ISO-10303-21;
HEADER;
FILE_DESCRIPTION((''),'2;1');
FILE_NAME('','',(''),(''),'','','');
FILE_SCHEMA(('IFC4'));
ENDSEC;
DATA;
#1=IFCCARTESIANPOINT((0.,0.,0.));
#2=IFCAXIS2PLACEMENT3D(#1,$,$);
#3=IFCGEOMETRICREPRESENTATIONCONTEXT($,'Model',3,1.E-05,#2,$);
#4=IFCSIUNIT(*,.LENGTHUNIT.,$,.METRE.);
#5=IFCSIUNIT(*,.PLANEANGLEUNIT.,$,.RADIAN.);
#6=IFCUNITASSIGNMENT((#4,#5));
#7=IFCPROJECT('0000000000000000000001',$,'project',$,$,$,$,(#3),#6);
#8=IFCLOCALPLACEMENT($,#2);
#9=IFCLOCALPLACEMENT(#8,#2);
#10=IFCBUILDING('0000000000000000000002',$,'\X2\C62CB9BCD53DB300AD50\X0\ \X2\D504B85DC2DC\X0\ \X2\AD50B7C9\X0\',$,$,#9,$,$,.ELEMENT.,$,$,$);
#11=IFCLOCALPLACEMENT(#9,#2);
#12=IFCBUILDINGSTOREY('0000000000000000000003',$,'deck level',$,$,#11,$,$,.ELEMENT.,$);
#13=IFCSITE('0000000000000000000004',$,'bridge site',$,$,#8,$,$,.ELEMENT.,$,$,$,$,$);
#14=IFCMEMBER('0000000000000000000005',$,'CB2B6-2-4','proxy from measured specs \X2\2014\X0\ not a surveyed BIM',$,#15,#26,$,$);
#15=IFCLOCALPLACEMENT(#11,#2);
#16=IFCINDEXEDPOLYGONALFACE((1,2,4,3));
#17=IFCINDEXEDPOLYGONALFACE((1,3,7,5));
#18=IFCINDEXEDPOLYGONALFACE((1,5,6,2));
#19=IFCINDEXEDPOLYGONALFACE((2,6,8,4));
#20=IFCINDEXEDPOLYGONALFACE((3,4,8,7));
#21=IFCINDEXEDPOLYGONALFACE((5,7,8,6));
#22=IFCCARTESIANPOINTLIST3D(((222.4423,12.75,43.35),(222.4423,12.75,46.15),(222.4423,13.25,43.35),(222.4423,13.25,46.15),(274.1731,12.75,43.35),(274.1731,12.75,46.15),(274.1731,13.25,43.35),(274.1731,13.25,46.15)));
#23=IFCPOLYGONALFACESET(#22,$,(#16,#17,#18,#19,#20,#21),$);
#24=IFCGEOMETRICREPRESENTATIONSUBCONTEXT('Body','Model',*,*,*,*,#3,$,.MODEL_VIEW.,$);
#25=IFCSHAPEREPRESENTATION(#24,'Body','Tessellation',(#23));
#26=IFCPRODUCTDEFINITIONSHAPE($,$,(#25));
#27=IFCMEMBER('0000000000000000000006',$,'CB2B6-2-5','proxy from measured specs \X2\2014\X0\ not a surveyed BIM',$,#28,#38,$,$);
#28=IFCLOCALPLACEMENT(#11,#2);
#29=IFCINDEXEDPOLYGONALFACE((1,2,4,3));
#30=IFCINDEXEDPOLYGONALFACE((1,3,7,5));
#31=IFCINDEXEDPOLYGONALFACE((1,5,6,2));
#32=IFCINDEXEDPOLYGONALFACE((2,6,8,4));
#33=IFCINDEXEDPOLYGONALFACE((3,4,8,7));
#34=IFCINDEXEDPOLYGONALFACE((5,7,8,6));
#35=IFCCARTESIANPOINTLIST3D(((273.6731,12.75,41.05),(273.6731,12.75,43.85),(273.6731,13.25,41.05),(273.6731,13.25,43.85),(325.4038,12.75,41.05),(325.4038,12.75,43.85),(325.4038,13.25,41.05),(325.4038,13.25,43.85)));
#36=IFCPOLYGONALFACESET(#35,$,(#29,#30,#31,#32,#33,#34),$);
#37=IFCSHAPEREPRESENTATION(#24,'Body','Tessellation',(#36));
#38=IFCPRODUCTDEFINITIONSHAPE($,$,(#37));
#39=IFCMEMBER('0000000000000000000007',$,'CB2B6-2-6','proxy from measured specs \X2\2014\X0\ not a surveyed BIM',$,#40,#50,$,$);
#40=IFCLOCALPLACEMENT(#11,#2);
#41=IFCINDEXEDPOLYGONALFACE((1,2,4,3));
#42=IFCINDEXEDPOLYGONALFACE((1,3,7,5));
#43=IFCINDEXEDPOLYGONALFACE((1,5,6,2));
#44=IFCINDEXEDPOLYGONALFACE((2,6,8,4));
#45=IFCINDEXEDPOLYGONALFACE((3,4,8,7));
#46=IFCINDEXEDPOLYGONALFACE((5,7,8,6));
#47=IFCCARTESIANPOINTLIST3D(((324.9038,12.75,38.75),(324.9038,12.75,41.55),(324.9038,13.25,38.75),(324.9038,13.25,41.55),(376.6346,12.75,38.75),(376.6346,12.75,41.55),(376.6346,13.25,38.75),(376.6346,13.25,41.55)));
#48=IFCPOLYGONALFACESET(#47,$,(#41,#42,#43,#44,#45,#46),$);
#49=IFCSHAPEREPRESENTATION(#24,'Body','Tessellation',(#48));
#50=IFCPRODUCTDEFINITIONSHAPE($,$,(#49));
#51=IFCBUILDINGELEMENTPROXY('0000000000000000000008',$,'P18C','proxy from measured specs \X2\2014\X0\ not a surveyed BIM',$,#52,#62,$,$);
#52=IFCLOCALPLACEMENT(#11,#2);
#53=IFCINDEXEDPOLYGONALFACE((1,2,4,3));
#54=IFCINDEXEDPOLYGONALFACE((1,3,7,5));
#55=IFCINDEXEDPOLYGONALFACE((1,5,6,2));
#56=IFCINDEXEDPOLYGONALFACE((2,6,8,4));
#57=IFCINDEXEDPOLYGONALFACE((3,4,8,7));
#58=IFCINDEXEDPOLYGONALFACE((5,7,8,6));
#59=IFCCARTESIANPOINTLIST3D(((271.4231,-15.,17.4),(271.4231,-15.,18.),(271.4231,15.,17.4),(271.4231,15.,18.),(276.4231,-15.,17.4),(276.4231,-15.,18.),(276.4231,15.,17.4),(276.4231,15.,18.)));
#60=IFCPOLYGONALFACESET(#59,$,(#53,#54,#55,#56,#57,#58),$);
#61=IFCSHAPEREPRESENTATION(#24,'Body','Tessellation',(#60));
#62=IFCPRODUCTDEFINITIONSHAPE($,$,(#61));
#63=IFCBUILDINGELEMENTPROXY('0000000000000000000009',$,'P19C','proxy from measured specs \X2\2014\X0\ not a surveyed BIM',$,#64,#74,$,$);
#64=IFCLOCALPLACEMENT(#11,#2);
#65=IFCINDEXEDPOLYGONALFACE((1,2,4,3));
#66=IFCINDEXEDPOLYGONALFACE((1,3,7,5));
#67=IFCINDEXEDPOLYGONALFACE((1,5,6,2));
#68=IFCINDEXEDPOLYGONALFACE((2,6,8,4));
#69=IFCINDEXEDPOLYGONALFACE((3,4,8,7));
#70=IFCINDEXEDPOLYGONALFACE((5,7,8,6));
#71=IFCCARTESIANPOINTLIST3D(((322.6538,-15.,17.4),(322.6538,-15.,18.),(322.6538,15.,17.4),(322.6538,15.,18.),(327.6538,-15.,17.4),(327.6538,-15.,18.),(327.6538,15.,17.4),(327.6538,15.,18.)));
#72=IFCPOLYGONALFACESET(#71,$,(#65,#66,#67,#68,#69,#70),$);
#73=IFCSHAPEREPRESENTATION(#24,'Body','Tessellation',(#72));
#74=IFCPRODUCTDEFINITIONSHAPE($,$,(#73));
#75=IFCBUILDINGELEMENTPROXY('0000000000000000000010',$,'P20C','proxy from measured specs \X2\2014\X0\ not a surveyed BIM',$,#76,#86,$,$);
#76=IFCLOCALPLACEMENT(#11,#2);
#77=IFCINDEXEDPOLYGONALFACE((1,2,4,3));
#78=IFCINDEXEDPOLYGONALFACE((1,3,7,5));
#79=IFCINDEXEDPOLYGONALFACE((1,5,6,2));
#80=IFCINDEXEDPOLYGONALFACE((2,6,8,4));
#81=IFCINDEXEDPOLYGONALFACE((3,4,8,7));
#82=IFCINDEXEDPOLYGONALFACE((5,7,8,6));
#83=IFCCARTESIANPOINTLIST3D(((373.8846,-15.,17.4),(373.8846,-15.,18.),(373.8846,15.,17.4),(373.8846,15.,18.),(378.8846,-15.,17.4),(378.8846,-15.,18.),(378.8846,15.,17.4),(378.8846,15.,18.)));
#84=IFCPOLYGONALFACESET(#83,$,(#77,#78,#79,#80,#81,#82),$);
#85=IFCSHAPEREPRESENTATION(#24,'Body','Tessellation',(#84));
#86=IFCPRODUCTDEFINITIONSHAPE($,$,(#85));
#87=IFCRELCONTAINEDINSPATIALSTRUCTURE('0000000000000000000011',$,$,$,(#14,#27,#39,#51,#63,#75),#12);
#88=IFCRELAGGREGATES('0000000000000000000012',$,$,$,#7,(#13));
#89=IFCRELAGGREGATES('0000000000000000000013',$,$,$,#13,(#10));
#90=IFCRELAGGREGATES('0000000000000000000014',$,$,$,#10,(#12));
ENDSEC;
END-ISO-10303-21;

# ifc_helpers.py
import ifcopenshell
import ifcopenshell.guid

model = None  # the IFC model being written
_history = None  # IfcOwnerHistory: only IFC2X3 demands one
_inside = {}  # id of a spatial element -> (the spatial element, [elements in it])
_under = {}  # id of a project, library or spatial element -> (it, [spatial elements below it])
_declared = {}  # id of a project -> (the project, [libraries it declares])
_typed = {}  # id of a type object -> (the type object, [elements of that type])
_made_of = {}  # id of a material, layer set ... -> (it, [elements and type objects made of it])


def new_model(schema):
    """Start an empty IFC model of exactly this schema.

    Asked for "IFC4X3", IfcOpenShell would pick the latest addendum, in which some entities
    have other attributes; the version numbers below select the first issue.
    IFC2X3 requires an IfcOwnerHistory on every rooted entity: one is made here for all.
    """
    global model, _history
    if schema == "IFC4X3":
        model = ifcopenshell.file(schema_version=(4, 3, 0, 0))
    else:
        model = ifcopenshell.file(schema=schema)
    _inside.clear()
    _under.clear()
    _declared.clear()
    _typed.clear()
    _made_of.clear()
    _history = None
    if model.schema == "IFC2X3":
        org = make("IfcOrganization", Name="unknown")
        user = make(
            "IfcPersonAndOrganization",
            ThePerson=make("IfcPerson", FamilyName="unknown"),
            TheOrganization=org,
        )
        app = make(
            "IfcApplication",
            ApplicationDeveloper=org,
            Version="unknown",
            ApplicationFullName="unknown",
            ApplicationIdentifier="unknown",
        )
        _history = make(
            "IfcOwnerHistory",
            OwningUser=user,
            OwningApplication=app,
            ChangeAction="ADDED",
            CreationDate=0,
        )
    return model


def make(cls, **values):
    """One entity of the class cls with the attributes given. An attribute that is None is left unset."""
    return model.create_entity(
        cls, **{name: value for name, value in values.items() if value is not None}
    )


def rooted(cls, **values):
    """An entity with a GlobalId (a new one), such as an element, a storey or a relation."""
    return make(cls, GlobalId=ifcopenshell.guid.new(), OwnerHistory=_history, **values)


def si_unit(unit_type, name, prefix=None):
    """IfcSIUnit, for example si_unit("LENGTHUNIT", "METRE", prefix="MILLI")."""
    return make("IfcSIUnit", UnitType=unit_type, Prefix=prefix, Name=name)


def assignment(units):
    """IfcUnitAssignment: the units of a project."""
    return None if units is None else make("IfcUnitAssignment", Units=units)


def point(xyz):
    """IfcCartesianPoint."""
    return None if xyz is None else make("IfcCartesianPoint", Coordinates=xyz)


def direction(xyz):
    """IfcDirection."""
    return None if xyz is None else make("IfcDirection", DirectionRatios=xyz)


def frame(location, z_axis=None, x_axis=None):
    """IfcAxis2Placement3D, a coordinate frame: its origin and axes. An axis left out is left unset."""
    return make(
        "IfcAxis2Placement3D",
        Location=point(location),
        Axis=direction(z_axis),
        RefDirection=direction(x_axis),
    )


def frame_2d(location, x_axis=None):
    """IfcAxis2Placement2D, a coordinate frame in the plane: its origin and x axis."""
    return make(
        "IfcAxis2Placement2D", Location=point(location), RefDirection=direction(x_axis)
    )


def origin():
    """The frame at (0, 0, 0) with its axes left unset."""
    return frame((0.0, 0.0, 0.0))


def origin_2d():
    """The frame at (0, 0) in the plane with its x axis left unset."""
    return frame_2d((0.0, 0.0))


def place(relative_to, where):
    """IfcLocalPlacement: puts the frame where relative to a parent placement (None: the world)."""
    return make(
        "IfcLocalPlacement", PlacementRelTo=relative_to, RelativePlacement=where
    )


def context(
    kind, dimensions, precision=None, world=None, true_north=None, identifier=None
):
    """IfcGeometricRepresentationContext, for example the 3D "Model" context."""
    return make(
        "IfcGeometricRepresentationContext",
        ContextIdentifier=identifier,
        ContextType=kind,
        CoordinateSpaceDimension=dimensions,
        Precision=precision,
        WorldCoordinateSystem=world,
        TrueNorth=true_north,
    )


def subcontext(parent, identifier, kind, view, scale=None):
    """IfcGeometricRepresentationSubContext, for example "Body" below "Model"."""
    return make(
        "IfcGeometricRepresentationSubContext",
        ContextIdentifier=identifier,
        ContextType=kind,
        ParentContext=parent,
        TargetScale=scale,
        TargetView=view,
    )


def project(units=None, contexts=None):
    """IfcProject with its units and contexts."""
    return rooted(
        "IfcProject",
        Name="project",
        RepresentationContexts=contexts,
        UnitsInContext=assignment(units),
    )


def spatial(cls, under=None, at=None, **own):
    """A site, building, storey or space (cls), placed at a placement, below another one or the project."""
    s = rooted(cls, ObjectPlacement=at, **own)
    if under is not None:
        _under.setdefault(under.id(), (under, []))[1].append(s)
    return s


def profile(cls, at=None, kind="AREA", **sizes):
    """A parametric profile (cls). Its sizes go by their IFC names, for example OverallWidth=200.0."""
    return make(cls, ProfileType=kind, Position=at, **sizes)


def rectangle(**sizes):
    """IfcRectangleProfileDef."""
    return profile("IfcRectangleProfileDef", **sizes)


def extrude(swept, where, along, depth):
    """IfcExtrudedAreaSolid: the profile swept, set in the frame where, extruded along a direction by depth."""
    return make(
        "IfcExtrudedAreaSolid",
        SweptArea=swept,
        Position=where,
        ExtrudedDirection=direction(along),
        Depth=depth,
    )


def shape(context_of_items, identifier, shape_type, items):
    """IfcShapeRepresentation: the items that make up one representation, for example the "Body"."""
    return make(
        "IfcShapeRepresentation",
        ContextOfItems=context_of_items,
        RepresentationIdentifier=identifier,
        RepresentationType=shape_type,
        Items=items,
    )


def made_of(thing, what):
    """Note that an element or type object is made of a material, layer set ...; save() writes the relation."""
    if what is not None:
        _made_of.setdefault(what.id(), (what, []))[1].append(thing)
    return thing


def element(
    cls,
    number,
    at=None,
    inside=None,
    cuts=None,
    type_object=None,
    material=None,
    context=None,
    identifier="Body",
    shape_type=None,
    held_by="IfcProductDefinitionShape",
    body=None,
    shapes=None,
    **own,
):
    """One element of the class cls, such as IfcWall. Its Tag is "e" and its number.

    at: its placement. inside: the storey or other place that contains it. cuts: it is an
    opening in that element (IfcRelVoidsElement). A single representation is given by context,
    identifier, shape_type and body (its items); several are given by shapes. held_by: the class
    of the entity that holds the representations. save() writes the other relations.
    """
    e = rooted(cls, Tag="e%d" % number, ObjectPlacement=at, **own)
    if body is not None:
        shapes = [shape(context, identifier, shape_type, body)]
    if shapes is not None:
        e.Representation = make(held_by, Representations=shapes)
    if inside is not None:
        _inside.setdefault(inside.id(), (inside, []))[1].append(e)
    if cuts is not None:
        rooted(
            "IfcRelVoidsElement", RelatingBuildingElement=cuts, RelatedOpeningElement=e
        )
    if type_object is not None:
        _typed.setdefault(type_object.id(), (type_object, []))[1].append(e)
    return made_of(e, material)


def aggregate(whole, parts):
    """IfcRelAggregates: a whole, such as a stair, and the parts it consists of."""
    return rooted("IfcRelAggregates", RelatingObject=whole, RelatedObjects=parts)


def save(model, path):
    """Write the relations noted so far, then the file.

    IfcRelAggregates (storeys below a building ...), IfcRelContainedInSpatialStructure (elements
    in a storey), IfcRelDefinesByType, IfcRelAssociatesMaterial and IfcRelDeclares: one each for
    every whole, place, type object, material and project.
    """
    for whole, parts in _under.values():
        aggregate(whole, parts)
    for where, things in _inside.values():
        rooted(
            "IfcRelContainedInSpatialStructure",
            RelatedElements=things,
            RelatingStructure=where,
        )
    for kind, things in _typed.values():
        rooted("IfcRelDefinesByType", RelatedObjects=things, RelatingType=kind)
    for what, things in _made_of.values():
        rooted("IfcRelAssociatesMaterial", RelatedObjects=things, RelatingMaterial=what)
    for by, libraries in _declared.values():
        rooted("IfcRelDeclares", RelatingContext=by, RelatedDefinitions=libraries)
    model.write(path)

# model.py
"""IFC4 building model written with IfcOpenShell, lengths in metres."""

from ifc_helpers import new_model, si_unit, frame, origin, origin_2d, place, context, subcontext, project, spatial, rectangle, extrude, element, save


model = new_model("IFC4")

# Units and contexts
model_context = context("Model", 3, precision=1e-05, world=origin())
body_context = subcontext(model_context, "Body", "Model", "MODEL_VIEW")
ifc_project = project(units=[si_unit("LENGTHUNIT", "METRE"), si_unit("PLANEANGLEUNIT", "RADIAN")], contexts=[model_context])

# Site, building, storey
site_placement = place(None, origin())
site = spatial("IfcSite", under=ifc_project, at=site_placement, Name="bridge site", CompositionType="ELEMENT")
building_placement = place(site_placement, origin())
building = spatial("IfcBuilding", under=site, at=building_placement, Name="올림픽대교 프록시 교량", CompositionType="ELEMENT")
storey_placement = place(building_placement, origin())
storey = spatial("IfcBuildingStorey", under=building, at=storey_placement, Name="deck level", CompositionType="ELEMENT")

# Members
member_1_placement = place(storey_placement, frame((248.3077, 13.0, 43.35)))
element("IfcMember", 1, at=member_1_placement, inside=storey, Name="CB2B6-2-4", Description="proxy from measured specs — not a surveyed BIM", context=body_context, shape_type="SweptSolid", body=[
    extrude(rectangle(XDim=51.7308, YDim=0.5, at=origin_2d()), origin(), (0.0, 0.0, 1.0), 2.8),
])
for number, where, name in (
    (2, (299.5385, 13.0, 41.05), "CB2B6-2-5"),
    (3, (350.7692, 13.0, 38.75), "CB2B6-2-6"),
):
    element("IfcMember", number, at=place(storey_placement, frame(where)), inside=storey, Name=name, Description="proxy from measured specs — not a surveyed BIM", context=body_context, shape_type="SweptSolid", body=[
        extrude(rectangle(XDim=51.7308, YDim=0.5, at=origin_2d()), origin(), (0.0, 0.0, 1.0), 2.8),
    ])

# Building element proxies
for number, where, name in (
    (4, (273.9231, 0.0, 17.4), "P18C"),
    (5, (325.1538, 0.0, 17.4), "P19C"),
    (6, (376.3846, 0.0, 17.4), "P20C"),
):
    element("IfcBuildingElementProxy", number, at=place(storey_placement, frame(where)), inside=storey, Name=name, Description="proxy from measured specs — not a surveyed BIM", context=body_context, shape_type="SweptSolid", body=[
        extrude(rectangle(XDim=5.0, YDim=30.0, at=origin_2d()), origin(), (0.0, 0.0, 1.0), 0.6),
    ])

save(model, "model.ifc")
